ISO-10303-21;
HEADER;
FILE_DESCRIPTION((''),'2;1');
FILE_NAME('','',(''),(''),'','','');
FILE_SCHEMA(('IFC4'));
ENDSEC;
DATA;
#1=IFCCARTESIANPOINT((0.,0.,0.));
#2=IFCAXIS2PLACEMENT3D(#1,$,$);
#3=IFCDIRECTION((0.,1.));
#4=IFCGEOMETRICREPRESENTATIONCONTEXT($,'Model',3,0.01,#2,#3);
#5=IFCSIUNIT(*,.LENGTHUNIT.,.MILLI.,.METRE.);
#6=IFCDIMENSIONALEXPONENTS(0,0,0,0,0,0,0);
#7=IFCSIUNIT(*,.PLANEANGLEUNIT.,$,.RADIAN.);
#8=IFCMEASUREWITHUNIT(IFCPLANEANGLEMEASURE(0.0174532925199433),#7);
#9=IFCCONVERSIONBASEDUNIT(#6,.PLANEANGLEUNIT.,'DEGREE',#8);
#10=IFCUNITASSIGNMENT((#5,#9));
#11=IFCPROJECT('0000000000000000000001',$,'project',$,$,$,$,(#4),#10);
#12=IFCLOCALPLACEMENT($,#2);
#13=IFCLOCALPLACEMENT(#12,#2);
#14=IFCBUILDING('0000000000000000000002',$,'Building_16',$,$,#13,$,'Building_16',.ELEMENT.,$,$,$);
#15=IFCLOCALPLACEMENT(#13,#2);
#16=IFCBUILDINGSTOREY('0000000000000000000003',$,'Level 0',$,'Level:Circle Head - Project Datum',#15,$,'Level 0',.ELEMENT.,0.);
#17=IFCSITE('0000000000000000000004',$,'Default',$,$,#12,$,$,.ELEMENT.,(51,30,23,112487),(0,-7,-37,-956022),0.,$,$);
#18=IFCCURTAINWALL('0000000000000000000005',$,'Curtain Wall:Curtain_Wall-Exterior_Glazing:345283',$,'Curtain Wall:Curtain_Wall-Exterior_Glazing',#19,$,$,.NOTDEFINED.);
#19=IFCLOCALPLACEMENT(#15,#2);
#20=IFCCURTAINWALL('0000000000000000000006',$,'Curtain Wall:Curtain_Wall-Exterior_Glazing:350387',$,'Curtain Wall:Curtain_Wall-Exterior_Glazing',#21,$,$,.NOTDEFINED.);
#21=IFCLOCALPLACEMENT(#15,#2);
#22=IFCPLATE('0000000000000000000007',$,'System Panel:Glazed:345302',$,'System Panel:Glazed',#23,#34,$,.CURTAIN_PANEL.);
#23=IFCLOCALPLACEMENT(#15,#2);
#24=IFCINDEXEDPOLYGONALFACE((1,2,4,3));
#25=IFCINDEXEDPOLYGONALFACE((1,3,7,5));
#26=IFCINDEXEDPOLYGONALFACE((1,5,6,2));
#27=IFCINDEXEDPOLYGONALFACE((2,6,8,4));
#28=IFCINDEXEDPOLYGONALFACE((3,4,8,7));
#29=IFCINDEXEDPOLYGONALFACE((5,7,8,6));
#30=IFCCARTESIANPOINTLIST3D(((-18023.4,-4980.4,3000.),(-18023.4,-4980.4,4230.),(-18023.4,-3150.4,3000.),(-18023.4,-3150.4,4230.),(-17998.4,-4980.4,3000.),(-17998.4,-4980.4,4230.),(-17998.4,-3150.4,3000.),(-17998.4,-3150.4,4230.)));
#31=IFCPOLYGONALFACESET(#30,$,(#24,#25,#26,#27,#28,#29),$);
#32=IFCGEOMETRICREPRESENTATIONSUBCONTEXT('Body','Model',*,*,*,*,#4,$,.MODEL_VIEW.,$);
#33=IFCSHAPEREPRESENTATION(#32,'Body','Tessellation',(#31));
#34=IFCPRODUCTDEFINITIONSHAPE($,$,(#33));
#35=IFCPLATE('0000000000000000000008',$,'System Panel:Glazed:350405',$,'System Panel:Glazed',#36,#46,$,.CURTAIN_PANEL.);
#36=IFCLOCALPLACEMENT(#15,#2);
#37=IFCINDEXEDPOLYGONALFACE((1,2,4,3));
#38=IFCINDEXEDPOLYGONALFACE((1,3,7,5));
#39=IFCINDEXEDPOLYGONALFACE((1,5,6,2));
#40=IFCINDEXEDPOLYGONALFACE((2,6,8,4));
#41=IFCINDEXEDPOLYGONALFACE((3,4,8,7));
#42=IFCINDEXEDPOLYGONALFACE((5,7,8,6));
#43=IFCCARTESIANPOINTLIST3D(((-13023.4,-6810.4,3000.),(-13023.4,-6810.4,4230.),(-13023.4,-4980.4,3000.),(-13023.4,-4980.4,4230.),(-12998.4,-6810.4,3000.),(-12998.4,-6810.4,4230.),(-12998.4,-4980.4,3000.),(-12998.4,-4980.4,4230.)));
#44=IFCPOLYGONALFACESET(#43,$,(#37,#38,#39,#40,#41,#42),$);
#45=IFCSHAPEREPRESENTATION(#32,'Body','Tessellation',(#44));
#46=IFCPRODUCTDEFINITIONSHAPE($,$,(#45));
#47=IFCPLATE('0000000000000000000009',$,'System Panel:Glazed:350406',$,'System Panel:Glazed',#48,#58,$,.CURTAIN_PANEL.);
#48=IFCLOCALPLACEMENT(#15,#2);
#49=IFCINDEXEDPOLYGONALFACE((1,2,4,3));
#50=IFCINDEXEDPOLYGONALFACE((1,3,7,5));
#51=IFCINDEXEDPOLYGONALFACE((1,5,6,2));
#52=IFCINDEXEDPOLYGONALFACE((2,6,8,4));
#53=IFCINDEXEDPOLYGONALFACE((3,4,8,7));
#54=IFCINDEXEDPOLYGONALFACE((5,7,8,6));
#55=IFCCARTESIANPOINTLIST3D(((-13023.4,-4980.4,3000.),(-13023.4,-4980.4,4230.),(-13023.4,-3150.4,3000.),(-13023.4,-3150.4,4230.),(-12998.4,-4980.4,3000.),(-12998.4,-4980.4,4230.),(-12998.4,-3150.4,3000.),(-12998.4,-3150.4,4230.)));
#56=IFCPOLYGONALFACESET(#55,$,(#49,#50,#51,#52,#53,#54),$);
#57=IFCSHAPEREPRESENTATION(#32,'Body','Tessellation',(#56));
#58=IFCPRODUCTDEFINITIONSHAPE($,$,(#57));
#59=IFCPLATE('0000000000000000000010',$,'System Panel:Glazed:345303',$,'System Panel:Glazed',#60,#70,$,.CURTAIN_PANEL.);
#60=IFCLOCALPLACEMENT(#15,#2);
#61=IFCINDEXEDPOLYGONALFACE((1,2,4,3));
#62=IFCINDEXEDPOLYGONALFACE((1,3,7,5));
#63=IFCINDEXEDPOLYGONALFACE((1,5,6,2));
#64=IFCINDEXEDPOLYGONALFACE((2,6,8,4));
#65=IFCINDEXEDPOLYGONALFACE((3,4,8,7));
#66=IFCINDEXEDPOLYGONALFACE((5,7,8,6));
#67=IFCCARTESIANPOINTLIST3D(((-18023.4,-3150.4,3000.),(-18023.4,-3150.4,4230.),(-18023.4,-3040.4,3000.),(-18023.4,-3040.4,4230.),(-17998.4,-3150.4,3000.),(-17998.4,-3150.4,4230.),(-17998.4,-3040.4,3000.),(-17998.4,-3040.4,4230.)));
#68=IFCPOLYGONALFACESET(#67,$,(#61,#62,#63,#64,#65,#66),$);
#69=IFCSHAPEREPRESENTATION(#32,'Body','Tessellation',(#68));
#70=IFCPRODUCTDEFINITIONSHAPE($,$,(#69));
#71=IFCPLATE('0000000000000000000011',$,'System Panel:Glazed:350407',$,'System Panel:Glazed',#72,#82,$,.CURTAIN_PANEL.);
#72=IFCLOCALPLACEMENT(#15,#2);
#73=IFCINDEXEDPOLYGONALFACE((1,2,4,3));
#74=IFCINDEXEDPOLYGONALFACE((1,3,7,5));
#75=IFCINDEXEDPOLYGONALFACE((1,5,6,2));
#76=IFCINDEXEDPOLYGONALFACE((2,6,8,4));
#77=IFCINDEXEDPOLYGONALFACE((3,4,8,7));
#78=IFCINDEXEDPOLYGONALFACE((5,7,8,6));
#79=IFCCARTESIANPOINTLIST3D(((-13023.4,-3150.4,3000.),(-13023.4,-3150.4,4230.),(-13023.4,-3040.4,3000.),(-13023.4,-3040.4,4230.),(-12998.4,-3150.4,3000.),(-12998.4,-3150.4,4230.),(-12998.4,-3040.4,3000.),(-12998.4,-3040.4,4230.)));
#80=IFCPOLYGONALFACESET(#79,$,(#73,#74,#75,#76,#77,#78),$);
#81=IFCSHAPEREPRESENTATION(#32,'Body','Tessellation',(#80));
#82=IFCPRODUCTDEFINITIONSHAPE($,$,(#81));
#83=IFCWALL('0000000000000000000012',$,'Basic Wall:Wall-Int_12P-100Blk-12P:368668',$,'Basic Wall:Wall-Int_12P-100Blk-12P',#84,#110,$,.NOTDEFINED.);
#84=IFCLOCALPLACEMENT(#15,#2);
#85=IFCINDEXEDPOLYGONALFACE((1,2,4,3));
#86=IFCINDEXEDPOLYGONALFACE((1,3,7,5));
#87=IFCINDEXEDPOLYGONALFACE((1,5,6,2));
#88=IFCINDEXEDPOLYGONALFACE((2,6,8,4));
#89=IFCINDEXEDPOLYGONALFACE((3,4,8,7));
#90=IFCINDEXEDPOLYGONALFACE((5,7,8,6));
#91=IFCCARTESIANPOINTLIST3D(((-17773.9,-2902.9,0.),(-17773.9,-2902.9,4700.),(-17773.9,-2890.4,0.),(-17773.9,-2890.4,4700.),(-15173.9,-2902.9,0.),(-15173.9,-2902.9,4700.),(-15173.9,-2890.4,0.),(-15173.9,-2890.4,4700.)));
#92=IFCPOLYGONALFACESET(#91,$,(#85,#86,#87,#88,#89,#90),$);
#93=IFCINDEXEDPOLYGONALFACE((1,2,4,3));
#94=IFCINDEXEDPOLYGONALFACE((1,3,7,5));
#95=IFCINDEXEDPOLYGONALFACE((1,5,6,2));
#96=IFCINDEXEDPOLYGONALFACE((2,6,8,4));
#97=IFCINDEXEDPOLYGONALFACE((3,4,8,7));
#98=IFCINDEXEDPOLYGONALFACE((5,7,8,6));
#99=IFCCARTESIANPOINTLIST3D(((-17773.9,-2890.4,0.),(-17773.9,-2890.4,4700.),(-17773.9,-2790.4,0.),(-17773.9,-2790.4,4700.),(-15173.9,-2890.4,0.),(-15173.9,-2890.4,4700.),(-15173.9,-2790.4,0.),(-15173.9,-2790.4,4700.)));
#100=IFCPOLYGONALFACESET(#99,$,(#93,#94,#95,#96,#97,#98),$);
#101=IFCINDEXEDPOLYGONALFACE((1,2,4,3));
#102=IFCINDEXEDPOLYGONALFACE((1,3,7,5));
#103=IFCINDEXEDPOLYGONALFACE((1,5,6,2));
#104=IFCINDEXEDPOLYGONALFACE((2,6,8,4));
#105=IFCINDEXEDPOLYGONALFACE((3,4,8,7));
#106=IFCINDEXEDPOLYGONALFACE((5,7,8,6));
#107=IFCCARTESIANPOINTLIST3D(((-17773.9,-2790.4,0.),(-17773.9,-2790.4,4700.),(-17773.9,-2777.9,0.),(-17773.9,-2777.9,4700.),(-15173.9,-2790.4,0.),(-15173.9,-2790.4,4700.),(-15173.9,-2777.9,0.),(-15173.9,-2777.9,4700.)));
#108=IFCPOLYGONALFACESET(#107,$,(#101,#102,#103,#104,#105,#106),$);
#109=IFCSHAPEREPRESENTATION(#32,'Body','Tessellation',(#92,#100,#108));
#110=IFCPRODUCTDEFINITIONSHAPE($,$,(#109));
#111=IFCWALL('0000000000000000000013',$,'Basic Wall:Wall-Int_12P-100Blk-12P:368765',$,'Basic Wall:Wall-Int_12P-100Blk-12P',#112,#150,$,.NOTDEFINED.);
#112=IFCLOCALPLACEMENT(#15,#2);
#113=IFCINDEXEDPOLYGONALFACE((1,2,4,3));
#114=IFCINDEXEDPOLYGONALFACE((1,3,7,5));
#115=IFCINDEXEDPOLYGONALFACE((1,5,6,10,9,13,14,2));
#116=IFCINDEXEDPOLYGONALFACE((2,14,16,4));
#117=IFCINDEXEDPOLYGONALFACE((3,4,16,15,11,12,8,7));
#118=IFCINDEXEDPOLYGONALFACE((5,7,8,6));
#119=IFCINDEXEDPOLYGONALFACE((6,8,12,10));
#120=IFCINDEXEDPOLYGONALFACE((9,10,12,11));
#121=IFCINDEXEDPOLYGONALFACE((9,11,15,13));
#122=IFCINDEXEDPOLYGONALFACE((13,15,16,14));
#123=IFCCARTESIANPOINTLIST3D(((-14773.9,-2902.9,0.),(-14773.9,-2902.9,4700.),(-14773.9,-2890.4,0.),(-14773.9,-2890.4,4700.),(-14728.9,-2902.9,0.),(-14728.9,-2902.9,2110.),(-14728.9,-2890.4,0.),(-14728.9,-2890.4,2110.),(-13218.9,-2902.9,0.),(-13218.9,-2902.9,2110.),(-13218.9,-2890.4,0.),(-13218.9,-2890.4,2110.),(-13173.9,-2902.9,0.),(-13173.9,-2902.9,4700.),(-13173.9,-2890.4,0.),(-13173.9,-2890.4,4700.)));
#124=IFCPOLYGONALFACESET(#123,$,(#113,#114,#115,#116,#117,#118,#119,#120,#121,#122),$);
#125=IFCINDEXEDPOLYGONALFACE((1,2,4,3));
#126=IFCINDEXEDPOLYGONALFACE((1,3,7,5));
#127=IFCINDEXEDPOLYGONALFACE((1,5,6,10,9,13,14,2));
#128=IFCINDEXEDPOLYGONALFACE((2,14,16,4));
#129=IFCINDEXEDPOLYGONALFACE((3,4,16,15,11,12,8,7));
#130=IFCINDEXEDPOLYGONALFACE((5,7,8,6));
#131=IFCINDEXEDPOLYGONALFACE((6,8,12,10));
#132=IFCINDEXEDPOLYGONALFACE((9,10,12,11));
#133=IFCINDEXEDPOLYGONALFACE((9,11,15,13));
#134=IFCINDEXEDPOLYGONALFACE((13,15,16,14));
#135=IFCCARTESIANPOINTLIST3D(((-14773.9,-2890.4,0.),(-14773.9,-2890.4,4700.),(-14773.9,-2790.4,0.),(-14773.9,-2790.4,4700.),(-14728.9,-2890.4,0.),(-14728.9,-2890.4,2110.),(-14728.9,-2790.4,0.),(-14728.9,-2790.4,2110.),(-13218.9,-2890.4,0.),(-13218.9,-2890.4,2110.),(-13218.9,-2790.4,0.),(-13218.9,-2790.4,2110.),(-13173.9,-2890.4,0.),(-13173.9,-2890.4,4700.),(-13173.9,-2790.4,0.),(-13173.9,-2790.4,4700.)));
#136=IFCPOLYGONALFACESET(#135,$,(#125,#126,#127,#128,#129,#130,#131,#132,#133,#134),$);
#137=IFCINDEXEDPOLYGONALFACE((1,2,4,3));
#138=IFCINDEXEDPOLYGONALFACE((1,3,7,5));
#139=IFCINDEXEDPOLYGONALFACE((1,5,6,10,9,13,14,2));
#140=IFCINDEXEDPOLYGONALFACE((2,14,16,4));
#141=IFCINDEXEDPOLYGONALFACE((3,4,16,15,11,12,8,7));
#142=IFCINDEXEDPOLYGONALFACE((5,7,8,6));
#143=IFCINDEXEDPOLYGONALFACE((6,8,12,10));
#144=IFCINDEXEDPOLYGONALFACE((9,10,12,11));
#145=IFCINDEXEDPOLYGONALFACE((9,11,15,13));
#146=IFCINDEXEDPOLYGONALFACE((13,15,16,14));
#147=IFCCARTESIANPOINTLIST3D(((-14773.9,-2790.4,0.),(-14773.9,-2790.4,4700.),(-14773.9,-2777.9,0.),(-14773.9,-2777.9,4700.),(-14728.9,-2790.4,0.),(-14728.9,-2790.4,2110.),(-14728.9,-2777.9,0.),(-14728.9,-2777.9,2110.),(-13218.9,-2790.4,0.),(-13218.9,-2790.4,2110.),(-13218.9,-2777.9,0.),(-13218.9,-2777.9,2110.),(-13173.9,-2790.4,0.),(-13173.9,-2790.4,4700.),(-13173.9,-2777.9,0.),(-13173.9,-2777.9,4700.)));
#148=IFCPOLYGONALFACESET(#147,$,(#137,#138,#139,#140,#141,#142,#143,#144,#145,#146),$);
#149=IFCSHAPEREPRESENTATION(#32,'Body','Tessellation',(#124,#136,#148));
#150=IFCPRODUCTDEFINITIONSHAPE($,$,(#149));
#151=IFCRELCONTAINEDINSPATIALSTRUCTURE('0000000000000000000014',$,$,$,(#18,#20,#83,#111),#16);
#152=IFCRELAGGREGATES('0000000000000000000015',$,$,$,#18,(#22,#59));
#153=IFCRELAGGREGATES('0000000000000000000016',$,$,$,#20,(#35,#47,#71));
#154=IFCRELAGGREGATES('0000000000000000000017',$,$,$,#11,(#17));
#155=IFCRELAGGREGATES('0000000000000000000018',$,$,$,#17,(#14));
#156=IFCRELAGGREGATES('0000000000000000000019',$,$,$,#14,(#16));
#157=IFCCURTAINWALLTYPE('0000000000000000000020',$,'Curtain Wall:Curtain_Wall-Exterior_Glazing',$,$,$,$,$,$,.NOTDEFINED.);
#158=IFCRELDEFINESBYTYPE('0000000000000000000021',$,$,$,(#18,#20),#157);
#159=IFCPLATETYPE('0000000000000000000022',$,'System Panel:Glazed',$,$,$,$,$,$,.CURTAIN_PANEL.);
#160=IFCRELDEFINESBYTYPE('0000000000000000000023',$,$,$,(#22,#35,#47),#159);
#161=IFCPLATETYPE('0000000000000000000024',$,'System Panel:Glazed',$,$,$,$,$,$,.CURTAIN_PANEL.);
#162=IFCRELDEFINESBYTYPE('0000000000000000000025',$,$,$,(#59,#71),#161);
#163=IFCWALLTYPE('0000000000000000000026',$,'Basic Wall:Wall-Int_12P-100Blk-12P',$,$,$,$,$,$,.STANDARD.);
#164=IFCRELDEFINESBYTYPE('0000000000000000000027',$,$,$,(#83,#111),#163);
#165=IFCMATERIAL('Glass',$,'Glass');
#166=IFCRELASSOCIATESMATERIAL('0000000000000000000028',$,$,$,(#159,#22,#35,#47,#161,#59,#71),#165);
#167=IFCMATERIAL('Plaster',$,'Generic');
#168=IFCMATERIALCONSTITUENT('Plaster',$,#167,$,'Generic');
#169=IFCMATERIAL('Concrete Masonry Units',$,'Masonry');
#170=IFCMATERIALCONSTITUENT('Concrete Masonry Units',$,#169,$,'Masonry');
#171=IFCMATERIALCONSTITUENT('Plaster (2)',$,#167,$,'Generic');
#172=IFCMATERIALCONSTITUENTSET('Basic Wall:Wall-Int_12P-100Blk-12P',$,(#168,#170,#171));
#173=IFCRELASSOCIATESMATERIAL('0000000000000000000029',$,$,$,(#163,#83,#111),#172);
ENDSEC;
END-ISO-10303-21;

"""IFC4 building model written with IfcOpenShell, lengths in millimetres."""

from ifc_helpers import new_model, entity, si_unit, converted_unit, direction, frame, origin, place, context, subcontext, project, spatial, indexed_curve, outline, extrude, source, transform, mapped, material, constituent, constituent_set, type_object, type_shapes, element, aggregate, save


model = new_model("IFC4")

# Units and contexts
model_context = context("Model", 3, precision=0.01, world=origin(), true_north=direction((0.0, 1.0)))
body_context = subcontext(model_context, "Body", "Model", "MODEL_VIEW")
ifc_project = project(units=[si_unit("LENGTHUNIT", "METRE", prefix="MILLI"), converted_unit("PLANEANGLEUNIT", "DEGREE", entity("IfcPlaneAngleMeasure", 0.0174532925199433), si_unit("PLANEANGLEUNIT", "RADIAN"), dimensions=[0, 0, 0, 0, 0, 0, 0])], contexts=[model_context])

# Site, building, storey
site_placement = place(None, origin())
site = spatial("IfcSite", under=ifc_project, at=site_placement, Name="Default", CompositionType="ELEMENT", RefLatitude=(51, 30, 23, 112487), RefLongitude=(0, -7, -37, -956022), RefElevation=0.0)
building_placement = place(site_placement, origin())
building = spatial("IfcBuilding", under=site, at=building_placement, Name="Building_16", LongName="Building_16", CompositionType="ELEMENT")
storey_placement = place(building_placement, origin())
storey = spatial("IfcBuildingStorey", under=building, at=storey_placement, Name="Level 0", ObjectType="Level:Circle Head - Project Datum", LongName="Level 0", CompositionType="ELEMENT", Elevation=0.0)

# Curtain walls
curtain_wall_type = type_object("IfcCurtainWallType", Name="Curtain Wall:Curtain_Wall-Exterior_Glazing", PredefinedType="NOTDEFINED")
curtain_wall_1_placement = place(storey_placement, origin())
curtain_wall_1 = element("IfcCurtainWall", 1, at=curtain_wall_1_placement, inside=storey, type_object=curtain_wall_type, Name="Curtain Wall:Curtain_Wall-Exterior_Glazing:345283", ObjectType="Curtain Wall:Curtain_Wall-Exterior_Glazing", PredefinedType="NOTDEFINED")
ifc_material_1 = material(Name="Glass", Category="Glass")
curtain_wall_2_placement = place(storey_placement, origin())
curtain_wall_2 = element("IfcCurtainWall", 2, at=curtain_wall_2_placement, inside=storey, type_object=curtain_wall_type, Name="Curtain Wall:Curtain_Wall-Exterior_Glazing:350387", ObjectType="Curtain Wall:Curtain_Wall-Exterior_Glazing", PredefinedType="NOTDEFINED")

# Plates
plate_type_1 = type_object("IfcPlateType", Name="System Panel:Glazed", PredefinedType="CURTAIN_PANEL", material=ifc_material_1)
shared_shape_1 = source(origin(), body_context, "Body", "SweptSolid", [
    extrude(outline(indexed_curve([(-12.5, -915.0), (12.5, -915.0), (12.5, 915.0), (-12.5, 915.0), (-12.5, -915.0)], self_intersect=False)), frame((0.0, 37.0, 0.0), z_axis=(0.0, 0.0, 1.0), x_axis=(0.0, 1.0, 0.0)), (0.0, 0.0, 1.0), 1230.0),
])
type_shapes(plate_type_1, [shared_shape_1])
plate_1_placement = place(curtain_wall_1_placement, frame((-17973.9, -4065.4, 3000.0), z_axis=(0.0, 0.0, 1.0), x_axis=(0.0, 1.0, 0.0)))
plate_1 = element("IfcPlate", 3, at=plate_1_placement, type_object=plate_type_1, material=ifc_material_1, Name="System Panel:Glazed:345302", ObjectType="System Panel:Glazed", PredefinedType="CURTAIN_PANEL", context=body_context, shape_type="MappedRepresentation", body=[
    mapped(shared_shape_1, transform((0.0, 0.0, 0.0), scale=1.0)),
])
plate_2_placement = place(curtain_wall_2_placement, frame((-12973.9, -5895.4, 3000.0), z_axis=(0.0, 0.0, 1.0), x_axis=(0.0, 1.0, 0.0)))
plate_2 = element("IfcPlate", 4, at=plate_2_placement, type_object=plate_type_1, material=ifc_material_1, Name="System Panel:Glazed:350405", ObjectType="System Panel:Glazed", PredefinedType="CURTAIN_PANEL", context=body_context, shape_type="MappedRepresentation", body=[
    mapped(shared_shape_1, transform((0.0, 0.0, 0.0), scale=1.0)),
])
plate_3_placement = place(curtain_wall_2_placement, frame((-12973.9, -4065.4, 3000.0), z_axis=(0.0, 0.0, 1.0), x_axis=(0.0, 1.0, 0.0)))
plate_3 = element("IfcPlate", 5, at=plate_3_placement, type_object=plate_type_1, material=ifc_material_1, Name="System Panel:Glazed:350406", ObjectType="System Panel:Glazed", PredefinedType="CURTAIN_PANEL", context=body_context, shape_type="MappedRepresentation", body=[
    mapped(shared_shape_1, transform((0.0, 0.0, 0.0), scale=1.0)),
])
plate_type_2 = type_object("IfcPlateType", Name="System Panel:Glazed", PredefinedType="CURTAIN_PANEL", material=ifc_material_1)
shared_shape_2 = source(origin(), body_context, "Body", "SweptSolid", [
    extrude(outline(indexed_curve([(-12.5, -55.0), (12.5, -55.0), (12.5, 55.0), (-12.5, 55.0), (-12.5, -55.0)], self_intersect=False)), frame((0.0, 37.0, 0.0), z_axis=(0.0, 0.0, 1.0), x_axis=(0.0, 1.0, 0.0)), (0.0, 0.0, 1.0), 1230.0),
])
type_shapes(plate_type_2, [shared_shape_2])
plate_4_placement = place(curtain_wall_1_placement, frame((-17973.9, -3095.4, 3000.0), z_axis=(0.0, 0.0, 1.0), x_axis=(0.0, 1.0, 0.0)))
plate_4 = element("IfcPlate", 6, at=plate_4_placement, type_object=plate_type_2, material=ifc_material_1, Name="System Panel:Glazed:345303", ObjectType="System Panel:Glazed", PredefinedType="CURTAIN_PANEL", context=body_context, shape_type="MappedRepresentation", body=[
    mapped(shared_shape_2, transform((0.0, 0.0, 0.0), scale=1.0)),
])
aggregate(curtain_wall_1, [plate_1, plate_4])
plate_5_placement = place(curtain_wall_2_placement, frame((-12973.9, -3095.4, 3000.0), z_axis=(0.0, 0.0, 1.0), x_axis=(0.0, 1.0, 0.0)))
plate_5 = element("IfcPlate", 7, at=plate_5_placement, type_object=plate_type_2, material=ifc_material_1, Name="System Panel:Glazed:350407", ObjectType="System Panel:Glazed", PredefinedType="CURTAIN_PANEL", context=body_context, shape_type="MappedRepresentation", body=[
    mapped(shared_shape_2, transform((0.0, 0.0, 0.0), scale=1.0)),
])
aggregate(curtain_wall_2, [plate_2, plate_3, plate_5])

# Wall
ifc_material_2 = material(Name="Plaster", Category="Generic")
ifc_constituent_1 = constituent(ifc_material_2, Name="Plaster", Category="Generic")
ifc_material_3 = material(Name="Concrete Masonry Units", Category="Masonry")
ifc_constituent_2 = constituent(ifc_material_3, Name="Concrete Masonry Units", Category="Masonry")
ifc_constituent_3 = constituent(ifc_material_2, Name="Plaster (2)", Category="Generic")
ifc_constituent_set = constituent_set(constituents=[ifc_constituent_1, ifc_constituent_2, ifc_constituent_3], Name="Basic Wall:Wall-Int_12P-100Blk-12P")
wall_type = type_object("IfcWallType", Name="Basic Wall:Wall-Int_12P-100Blk-12P", PredefinedType="STANDARD", material=ifc_constituent_set)
wall_1_placement = place(storey_placement, frame((-17773.9, -2840.4, 0.0)))
element("IfcWall", 8, at=wall_1_placement, inside=storey, type_object=wall_type, material=ifc_constituent_set, Name="Basic Wall:Wall-Int_12P-100Blk-12P:368668", ObjectType="Basic Wall:Wall-Int_12P-100Blk-12P", PredefinedType="NOTDEFINED", context=body_context, shape_type="SweptSolid", body=[
    extrude(outline(indexed_curve([(-6.3, -1300.0), (6.2, -1300.0), (6.3, 1300.0), (-6.2, 1300.0), (-6.3, -1300.0)], self_intersect=False)), frame((1300.0, -56.3, 0.0), z_axis=(0.0, 0.0, 1.0), x_axis=(0.0, 1.0, 0.0)), (0.0, 0.0, 1.0), 4700.0),
    extrude(outline(indexed_curve([(-1300.0, -50.0), (1300.0, -50.0), (1300.0, 50.0), (-1300.0, 50.0), (-1300.0, -50.0)], self_intersect=False)), frame((1300.0, 0.0, 0.0)), (0.0, 0.0, 1.0), 4700.0),
    extrude(outline(indexed_curve([(-6.3, -1300.0), (6.2, -1300.0), (6.3, 1300.0), (-6.2, 1300.0), (-6.3, -1300.0)], self_intersect=False)), frame((1300.0, 56.2, 0.0), z_axis=(0.0, 0.0, 1.0), x_axis=(0.0, -1.0, 0.0)), (0.0, 0.0, 1.0), 4700.0),
])

# Wall, opening
wall_2_placement = place(storey_placement, frame((-14773.9, -2840.4, 0.0)))
wall_2 = element("IfcWall", 9, at=wall_2_placement, inside=storey, type_object=wall_type, material=ifc_constituent_set, Name="Basic Wall:Wall-Int_12P-100Blk-12P:368765", ObjectType="Basic Wall:Wall-Int_12P-100Blk-12P", PredefinedType="NOTDEFINED", context=body_context, shape_type="SweptSolid", body=[
    extrude(outline(indexed_curve([(-755.0, -407.5), (-755.0, 1702.5), (-800.0, 1702.5), (-800.0, -2997.5), (800.0, -2997.5), (800.0, 1702.5), (755.0, 1702.5), (755.0, -407.5), (-755.0, -407.5)], self_intersect=False)), frame((800.0, -62.5, 1702.5), z_axis=(0.0, -1.0, 0.0), x_axis=(-1.0, 0.0, 0.0)), (0.0, 0.0, -1.0), 12.5),
    extrude(outline(indexed_curve([(-1702.5, -800.0), (2997.5, -800.0), (2997.5, 800.0), (-1702.5, 800.0), (-1702.5, 755.0), (407.5, 755.0), (407.5, -755.0), (-1702.5, -755.0), (-1702.5, -800.0)], self_intersect=False)), frame((800.0, -50.0, 1702.5), z_axis=(0.0, 1.0, 0.0), x_axis=(0.0, 0.0, 1.0)), (0.0, 0.0, 1.0), 100.0),
    extrude(outline(indexed_curve([(-1702.5, -800.0), (2997.5, -800.0), (2997.5, 800.0), (-1702.5, 800.0), (-1702.5, 755.0), (407.5, 755.0), (407.5, -755.0), (-1702.5, -755.0), (-1702.5, -800.0)], self_intersect=False)), frame((800.0, 50.0, 1702.5), z_axis=(0.0, 1.0, 0.0), x_axis=(0.0, 0.0, 1.0)), (0.0, 0.0, 1.0), 12.5),
])
opening_placement = place(wall_2_placement, frame((45.0, -62.5, 0.0)))
element("IfcOpeningElement", 10, at=opening_placement, cuts=wall_2, PredefinedType="OPENING", context=body_context, shape_type="SweptSolid", body=[
    extrude(outline(indexed_curve([(2110.0, 0.0), (2110.0, 1510.0), (0.0, 1510.0), (0.0, 0.0), (2110.0, 0.0)], self_intersect=False)), frame((0.0, 0.0, 0.0), z_axis=(0.0, 1.0, 0.0), x_axis=(0.0, 0.0, 1.0)), (0.0, 0.0, 1.0), 125.0),
])

save(model, "model.ifc")
